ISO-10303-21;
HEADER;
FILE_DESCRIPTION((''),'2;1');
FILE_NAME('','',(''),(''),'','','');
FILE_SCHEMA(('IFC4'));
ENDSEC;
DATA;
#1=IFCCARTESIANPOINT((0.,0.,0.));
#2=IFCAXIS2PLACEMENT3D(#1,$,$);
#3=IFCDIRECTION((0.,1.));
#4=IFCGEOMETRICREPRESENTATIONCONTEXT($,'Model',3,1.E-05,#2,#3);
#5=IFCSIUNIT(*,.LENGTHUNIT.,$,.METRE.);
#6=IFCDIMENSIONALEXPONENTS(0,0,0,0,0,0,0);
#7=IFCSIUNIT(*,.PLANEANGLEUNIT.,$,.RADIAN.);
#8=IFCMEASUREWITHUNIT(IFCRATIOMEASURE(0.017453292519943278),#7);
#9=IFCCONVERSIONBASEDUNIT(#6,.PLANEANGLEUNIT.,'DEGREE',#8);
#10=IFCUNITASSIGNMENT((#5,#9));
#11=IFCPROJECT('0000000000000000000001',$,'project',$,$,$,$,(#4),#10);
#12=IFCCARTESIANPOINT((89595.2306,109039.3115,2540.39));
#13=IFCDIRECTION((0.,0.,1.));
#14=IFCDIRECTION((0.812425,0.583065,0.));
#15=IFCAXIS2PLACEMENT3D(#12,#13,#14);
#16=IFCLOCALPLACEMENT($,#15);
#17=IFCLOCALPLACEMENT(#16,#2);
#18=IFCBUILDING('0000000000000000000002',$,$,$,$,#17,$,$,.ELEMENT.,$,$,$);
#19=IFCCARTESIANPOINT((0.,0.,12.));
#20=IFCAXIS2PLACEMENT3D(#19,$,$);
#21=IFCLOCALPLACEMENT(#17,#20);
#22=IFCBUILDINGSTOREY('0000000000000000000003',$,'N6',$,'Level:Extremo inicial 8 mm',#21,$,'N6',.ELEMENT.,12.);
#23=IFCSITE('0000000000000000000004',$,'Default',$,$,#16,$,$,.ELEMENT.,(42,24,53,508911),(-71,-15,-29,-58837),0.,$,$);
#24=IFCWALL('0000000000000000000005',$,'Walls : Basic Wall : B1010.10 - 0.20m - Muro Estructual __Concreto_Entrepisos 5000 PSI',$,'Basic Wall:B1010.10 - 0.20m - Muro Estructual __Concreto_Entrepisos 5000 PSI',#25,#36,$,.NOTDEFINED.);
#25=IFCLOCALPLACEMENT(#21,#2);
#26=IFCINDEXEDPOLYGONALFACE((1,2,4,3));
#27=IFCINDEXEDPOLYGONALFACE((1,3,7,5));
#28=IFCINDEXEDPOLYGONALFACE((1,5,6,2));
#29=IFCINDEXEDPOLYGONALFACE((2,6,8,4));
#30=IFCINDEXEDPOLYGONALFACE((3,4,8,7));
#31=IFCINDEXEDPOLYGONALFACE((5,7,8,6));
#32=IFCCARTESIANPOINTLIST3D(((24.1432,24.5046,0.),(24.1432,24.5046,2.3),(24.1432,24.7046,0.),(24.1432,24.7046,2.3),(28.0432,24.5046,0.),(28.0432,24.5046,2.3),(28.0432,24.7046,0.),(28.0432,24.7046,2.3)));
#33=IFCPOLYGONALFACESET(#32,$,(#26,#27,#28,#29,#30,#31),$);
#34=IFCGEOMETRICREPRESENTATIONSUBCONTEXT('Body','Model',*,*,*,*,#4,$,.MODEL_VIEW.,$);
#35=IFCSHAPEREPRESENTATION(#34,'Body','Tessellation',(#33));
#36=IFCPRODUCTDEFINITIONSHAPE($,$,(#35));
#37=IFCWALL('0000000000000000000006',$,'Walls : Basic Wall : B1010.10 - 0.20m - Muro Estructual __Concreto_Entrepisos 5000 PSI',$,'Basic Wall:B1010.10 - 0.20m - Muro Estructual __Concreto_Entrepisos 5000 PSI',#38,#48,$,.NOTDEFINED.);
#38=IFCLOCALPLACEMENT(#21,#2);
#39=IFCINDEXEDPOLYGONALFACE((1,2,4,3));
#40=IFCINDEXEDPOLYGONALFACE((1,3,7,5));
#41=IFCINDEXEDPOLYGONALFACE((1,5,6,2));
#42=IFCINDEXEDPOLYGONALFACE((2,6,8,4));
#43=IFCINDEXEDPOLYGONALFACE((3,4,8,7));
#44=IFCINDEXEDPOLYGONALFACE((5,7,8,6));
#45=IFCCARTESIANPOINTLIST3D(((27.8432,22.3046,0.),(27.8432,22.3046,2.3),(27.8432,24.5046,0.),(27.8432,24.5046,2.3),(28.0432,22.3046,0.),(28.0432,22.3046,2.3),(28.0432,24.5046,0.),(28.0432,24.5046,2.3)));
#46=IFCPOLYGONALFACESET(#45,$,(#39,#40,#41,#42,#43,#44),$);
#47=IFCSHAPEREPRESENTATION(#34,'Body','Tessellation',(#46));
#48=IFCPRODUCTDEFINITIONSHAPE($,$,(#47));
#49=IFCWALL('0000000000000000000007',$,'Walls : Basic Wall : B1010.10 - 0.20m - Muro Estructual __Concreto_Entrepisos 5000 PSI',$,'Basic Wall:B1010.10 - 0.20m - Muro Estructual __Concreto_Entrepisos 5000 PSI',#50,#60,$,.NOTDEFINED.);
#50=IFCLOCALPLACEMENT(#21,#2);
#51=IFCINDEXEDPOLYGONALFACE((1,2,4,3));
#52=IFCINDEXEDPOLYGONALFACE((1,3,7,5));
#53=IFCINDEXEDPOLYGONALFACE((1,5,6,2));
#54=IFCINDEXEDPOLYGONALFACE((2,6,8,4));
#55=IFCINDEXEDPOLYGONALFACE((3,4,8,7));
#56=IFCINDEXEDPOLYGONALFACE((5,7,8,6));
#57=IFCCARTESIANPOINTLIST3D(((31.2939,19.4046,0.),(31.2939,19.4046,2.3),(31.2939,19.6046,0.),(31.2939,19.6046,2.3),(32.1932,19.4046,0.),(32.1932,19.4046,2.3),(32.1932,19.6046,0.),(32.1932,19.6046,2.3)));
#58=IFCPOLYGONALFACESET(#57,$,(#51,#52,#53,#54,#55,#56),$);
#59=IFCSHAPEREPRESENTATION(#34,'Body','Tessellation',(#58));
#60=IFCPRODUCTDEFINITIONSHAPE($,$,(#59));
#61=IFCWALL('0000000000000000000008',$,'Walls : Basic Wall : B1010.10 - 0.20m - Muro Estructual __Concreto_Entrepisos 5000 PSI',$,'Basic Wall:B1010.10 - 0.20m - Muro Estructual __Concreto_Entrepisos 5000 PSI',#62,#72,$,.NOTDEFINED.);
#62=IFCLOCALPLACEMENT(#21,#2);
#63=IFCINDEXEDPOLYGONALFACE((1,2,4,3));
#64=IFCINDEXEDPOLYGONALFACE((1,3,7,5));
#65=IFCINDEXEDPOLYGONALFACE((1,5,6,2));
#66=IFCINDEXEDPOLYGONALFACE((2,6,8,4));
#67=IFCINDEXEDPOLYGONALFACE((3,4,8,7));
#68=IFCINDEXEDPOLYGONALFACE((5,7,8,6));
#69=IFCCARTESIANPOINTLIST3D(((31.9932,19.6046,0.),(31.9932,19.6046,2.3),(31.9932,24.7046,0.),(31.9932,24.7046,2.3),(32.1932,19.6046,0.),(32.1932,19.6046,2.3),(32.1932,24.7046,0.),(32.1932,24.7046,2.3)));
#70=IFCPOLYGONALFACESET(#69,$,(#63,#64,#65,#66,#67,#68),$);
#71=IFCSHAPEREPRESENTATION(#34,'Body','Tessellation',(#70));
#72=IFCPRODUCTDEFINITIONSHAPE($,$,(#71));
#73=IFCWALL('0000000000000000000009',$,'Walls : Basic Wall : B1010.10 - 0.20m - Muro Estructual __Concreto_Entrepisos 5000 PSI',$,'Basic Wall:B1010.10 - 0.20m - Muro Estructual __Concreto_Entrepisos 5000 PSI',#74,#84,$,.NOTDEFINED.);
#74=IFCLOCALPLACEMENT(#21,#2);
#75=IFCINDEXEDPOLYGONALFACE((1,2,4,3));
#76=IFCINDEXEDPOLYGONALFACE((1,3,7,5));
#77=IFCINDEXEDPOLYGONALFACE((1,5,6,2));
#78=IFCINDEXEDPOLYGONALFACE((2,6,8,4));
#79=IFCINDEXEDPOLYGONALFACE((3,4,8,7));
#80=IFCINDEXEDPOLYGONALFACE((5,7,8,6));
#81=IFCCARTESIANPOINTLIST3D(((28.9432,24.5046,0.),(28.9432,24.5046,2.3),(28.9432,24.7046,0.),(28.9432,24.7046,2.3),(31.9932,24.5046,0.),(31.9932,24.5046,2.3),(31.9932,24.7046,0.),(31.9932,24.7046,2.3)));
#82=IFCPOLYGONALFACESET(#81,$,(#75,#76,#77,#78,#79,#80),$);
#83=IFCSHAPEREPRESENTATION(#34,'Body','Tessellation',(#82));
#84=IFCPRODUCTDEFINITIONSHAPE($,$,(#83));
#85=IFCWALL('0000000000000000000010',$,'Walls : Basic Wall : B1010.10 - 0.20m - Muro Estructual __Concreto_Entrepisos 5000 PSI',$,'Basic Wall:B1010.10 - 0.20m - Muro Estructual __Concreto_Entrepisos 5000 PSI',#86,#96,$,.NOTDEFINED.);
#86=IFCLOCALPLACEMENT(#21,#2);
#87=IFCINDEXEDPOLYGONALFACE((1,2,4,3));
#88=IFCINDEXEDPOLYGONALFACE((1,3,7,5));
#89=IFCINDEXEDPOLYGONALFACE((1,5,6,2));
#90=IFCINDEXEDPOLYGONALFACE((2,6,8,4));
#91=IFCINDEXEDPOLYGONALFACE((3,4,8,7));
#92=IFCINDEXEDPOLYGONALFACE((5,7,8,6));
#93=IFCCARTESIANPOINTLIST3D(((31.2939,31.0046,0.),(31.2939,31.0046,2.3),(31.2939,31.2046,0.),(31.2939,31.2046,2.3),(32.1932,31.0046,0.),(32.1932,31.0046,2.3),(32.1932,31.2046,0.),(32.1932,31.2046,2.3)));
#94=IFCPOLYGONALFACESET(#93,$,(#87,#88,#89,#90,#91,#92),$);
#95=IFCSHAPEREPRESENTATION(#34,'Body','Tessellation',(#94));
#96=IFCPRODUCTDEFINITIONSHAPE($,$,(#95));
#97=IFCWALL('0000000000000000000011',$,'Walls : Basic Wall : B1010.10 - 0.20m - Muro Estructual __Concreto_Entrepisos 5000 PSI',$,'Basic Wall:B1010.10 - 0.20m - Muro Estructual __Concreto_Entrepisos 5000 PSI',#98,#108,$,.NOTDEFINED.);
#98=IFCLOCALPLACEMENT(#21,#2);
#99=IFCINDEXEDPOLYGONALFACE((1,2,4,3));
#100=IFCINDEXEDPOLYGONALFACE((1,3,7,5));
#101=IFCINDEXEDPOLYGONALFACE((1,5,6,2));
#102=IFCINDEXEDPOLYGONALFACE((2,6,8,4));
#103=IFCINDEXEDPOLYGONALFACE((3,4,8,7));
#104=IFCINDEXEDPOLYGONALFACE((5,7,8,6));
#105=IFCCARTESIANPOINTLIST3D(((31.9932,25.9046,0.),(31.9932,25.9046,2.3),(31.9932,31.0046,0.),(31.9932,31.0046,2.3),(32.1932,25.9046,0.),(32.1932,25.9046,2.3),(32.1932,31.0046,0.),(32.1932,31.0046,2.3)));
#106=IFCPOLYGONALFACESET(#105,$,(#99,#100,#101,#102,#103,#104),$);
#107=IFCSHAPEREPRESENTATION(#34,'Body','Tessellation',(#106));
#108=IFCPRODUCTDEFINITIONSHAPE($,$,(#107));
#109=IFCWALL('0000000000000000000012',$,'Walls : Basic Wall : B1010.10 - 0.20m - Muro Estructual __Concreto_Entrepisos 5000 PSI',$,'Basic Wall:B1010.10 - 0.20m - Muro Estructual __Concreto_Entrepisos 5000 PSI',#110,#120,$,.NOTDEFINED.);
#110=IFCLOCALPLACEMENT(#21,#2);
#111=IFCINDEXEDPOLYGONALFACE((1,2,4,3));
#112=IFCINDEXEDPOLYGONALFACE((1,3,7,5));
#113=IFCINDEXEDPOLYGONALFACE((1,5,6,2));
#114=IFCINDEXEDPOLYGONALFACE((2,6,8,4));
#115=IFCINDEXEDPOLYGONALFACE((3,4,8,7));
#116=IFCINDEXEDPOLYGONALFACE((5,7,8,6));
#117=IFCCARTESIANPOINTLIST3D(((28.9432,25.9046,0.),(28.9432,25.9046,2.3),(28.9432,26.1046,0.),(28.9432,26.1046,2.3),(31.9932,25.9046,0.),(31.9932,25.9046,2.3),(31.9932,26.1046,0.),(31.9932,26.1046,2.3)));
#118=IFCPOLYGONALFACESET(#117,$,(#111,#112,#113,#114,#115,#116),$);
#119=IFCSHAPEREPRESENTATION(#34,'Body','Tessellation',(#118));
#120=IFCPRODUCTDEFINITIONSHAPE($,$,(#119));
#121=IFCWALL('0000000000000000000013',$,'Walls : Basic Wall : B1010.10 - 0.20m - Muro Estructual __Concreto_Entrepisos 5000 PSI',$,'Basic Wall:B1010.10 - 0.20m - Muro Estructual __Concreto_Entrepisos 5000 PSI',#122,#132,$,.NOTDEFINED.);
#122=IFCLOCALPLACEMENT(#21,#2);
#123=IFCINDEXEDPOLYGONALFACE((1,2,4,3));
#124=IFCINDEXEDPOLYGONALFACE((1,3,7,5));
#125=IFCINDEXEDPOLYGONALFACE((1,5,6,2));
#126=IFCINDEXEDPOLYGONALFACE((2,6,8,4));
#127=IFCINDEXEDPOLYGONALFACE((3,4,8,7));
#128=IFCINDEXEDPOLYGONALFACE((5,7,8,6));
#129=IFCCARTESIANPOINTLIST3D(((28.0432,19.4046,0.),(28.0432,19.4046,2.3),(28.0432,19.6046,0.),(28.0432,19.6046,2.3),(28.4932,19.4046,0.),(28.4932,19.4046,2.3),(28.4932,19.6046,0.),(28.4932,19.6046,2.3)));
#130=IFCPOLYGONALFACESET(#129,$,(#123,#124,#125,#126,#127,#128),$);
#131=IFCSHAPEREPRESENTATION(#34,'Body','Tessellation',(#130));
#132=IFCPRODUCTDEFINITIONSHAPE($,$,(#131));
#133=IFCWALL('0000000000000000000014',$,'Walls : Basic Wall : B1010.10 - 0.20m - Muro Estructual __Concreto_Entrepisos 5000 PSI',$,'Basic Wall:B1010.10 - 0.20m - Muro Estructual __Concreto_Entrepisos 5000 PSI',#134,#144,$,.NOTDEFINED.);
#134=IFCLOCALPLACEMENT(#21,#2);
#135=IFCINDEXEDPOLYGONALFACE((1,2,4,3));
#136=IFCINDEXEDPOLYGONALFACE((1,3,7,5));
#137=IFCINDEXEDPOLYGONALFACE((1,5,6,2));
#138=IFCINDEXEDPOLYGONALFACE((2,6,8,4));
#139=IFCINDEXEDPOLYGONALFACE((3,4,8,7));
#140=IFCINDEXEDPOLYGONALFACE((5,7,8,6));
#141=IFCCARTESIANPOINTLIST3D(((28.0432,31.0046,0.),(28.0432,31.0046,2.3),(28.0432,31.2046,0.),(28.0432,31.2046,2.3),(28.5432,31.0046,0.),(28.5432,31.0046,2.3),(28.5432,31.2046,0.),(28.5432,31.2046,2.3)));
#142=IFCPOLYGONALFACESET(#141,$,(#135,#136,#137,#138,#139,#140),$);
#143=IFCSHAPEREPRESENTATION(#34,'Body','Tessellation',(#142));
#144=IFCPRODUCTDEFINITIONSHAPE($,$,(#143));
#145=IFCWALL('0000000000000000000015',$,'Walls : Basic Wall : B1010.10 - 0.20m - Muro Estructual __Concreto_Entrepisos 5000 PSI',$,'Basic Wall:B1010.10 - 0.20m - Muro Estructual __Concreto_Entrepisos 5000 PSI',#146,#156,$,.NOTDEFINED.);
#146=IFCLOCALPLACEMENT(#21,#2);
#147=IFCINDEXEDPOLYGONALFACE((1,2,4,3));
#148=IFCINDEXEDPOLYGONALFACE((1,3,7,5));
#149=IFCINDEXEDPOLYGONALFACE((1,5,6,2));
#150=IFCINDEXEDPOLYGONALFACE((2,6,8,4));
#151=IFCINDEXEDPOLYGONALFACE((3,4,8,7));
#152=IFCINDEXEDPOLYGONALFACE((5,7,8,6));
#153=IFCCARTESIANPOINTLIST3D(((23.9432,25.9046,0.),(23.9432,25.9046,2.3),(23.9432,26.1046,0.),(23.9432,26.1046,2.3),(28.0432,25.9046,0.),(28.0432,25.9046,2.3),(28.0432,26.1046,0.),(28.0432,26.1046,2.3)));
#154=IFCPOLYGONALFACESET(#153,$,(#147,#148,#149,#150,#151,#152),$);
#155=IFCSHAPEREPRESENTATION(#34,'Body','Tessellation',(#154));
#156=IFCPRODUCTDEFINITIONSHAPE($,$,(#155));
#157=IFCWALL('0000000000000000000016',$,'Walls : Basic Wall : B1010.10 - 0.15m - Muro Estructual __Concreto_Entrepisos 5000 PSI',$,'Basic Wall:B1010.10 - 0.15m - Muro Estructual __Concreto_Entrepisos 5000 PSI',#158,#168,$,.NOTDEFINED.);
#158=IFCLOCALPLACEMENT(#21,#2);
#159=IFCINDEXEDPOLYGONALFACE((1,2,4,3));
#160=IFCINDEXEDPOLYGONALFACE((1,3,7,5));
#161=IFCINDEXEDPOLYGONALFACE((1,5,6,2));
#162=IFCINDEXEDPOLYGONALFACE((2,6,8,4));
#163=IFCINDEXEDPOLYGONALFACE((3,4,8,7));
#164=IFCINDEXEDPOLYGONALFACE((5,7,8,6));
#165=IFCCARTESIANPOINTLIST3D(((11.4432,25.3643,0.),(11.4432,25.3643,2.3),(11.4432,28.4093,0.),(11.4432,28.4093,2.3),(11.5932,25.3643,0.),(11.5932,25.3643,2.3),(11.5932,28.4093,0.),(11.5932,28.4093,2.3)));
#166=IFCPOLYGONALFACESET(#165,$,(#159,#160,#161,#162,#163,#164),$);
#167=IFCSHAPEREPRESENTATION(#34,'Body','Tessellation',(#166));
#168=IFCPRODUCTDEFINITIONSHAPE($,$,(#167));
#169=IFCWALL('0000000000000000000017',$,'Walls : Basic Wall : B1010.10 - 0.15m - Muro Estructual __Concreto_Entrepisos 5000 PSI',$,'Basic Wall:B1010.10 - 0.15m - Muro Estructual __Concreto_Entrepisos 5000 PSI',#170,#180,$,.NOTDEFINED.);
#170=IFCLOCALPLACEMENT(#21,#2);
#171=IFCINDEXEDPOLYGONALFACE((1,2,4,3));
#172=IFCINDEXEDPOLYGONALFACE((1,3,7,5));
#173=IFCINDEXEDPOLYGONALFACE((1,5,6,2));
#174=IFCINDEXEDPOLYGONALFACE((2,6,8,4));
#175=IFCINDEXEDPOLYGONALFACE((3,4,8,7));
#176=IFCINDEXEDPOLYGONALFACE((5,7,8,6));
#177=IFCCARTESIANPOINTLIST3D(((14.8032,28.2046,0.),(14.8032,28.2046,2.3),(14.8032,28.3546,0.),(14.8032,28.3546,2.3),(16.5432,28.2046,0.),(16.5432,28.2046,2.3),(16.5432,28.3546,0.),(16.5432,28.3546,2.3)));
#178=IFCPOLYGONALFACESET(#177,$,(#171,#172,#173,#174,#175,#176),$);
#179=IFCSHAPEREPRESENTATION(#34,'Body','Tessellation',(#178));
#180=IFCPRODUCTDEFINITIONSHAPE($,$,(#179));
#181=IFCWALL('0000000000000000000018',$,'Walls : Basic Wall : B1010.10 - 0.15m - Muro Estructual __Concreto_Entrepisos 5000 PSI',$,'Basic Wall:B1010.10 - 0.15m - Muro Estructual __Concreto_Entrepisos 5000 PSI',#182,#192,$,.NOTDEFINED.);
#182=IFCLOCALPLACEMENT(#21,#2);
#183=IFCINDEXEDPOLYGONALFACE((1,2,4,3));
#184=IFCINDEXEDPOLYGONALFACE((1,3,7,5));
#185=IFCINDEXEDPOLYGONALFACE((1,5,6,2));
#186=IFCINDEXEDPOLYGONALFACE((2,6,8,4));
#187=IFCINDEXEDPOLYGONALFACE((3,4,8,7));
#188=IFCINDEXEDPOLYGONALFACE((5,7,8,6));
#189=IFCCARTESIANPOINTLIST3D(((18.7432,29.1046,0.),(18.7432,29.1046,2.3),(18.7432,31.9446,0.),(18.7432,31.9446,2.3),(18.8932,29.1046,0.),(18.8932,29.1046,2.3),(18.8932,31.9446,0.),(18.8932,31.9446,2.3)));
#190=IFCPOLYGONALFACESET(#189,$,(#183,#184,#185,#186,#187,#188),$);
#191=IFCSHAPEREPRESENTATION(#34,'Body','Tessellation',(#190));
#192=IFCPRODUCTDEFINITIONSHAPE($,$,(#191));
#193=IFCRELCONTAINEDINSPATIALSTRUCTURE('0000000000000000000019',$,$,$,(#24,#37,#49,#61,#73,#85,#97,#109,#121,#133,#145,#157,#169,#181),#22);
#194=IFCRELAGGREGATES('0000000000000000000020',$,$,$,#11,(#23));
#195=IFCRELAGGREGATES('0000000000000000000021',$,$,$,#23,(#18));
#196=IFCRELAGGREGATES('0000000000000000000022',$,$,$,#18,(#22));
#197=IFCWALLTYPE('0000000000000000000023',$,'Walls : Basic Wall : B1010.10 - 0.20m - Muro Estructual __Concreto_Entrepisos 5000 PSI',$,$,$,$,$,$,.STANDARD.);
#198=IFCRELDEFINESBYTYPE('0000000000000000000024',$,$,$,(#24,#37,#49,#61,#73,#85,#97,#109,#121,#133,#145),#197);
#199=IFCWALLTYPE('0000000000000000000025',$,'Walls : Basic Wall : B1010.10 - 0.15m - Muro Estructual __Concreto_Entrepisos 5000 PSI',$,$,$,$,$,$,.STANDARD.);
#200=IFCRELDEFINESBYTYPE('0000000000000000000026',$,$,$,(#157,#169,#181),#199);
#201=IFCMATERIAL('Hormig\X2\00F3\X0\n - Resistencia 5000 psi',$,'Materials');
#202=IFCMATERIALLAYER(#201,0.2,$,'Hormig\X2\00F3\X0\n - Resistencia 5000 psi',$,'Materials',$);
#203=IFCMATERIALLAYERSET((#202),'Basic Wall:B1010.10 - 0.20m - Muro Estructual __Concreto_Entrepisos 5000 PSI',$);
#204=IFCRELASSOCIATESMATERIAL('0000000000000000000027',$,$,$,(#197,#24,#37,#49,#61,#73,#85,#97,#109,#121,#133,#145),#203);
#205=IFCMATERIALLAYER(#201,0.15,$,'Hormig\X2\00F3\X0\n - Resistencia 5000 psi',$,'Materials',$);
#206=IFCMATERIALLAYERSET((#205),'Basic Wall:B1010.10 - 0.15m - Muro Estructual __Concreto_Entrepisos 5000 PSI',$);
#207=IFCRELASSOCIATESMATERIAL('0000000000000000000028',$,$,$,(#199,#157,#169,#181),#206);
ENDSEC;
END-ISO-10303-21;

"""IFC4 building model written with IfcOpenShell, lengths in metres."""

from ifc_helpers import new_model, entity, si_unit, converted_unit, direction, frame, frame_2d, origin, place, context, subcontext, project, spatial, rectangle, extrude, material, layer, layer_set, layer_usage, type_object, element, save


model = new_model("IFC4")

# Units and contexts
model_context = context("Model", 3, precision=1e-05, world=origin(), true_north=direction((0.0, 1.0)))
body_context = subcontext(model_context, "Body", "Model", "MODEL_VIEW")
ifc_project = project(units=[si_unit("LENGTHUNIT", "METRE"), converted_unit("PLANEANGLEUNIT", "DEGREE", entity("IfcRatioMeasure", 0.017453292519943278), si_unit("PLANEANGLEUNIT", "RADIAN"), dimensions=[0, 0, 0, 0, 0, 0, 0])], contexts=[model_context])

# Site, building, storey
site_placement = place(None, frame((89595.2306, 109039.3115, 2540.39), z_axis=(0.0, 0.0, 1.0), x_axis=(0.812425, 0.583065, 0.0)))
site = spatial("IfcSite", under=ifc_project, at=site_placement, Name="Default", CompositionType="ELEMENT", RefLatitude=(42, 24, 53, 508911), RefLongitude=(-71, -15, -29, -58837), RefElevation=0.0)
building_placement = place(site_placement, origin())
building = spatial("IfcBuilding", under=site, at=building_placement, CompositionType="ELEMENT")
storey_placement = place(building_placement, frame((0.0, 0.0, 12.0)))
storey = spatial("IfcBuildingStorey", under=building, at=storey_placement, Name="N6", ObjectType="Level:Extremo inicial 8 mm", LongName="N6", CompositionType="ELEMENT", Elevation=12.0)

# Walls
ifc_material_1 = material(Name="Hormigón - Resistencia 5000 psi", Category="Materials")
ifc_layer_1 = layer(ifc_material_1, 0.2, Name="Hormigón - Resistencia 5000 psi", Category="Materials")
ifc_layer_set_1 = layer_set([ifc_layer_1], Name="Basic Wall:B1010.10 - 0.20m - Muro Estructual __Concreto_Entrepisos 5000 PSI")
wall_type_1 = type_object("IfcWallType", Name="Walls : Basic Wall : B1010.10 - 0.20m - Muro Estructual __Concreto_Entrepisos 5000 PSI", PredefinedType="STANDARD", material=ifc_layer_set_1)
ifc_layer_usage_1 = layer_usage(ifc_layer_set_1, "AXIS2", "NEGATIVE", 0.1)
wall_1_placement = place(storey_placement, frame((24.1432, 24.6046, 0.0)))
element("IfcWall", 1, at=wall_1_placement, inside=storey, type_object=wall_type_1, material=ifc_layer_usage_1, Name="Walls : Basic Wall : B1010.10 - 0.20m - Muro Estructual __Concreto_Entrepisos 5000 PSI", ObjectType="Basic Wall:B1010.10 - 0.20m - Muro Estructual __Concreto_Entrepisos 5000 PSI", PredefinedType="NOTDEFINED", context=body_context, shape_type="SweptSolid", body=[
    extrude(rectangle(XDim=3.9, YDim=0.2, at=frame_2d((1.95, 0.0), x_axis=(-1.0, 0.0))), origin(), (0.0, 0.0, 1.0), 2.3),
])
ifc_layer_usage_2 = layer_usage(ifc_layer_set_1, "AXIS2", "NEGATIVE", 0.1)
wall_2_placement = place(storey_placement, frame((27.9432, 24.5046, 0.0), z_axis=(0.0, 0.0, 1.0), x_axis=(0.0, -1.0, 0.0)))
element("IfcWall", 2, at=wall_2_placement, inside=storey, type_object=wall_type_1, material=ifc_layer_usage_2, Name="Walls : Basic Wall : B1010.10 - 0.20m - Muro Estructual __Concreto_Entrepisos 5000 PSI", ObjectType="Basic Wall:B1010.10 - 0.20m - Muro Estructual __Concreto_Entrepisos 5000 PSI", PredefinedType="NOTDEFINED", context=body_context, shape_type="SweptSolid", body=[
    extrude(rectangle(XDim=2.2, YDim=0.2, at=frame_2d((1.1, 0.0), x_axis=(-1.0, 0.0))), origin(), (0.0, 0.0, 1.0), 2.3),
])
ifc_layer_usage_3 = layer_usage(ifc_layer_set_1, "AXIS2", "NEGATIVE", 0.1)
wall_3_placement = place(storey_placement, frame((31.2939, 19.5046, 0.0)))
element("IfcWall", 3, at=wall_3_placement, inside=storey, type_object=wall_type_1, material=ifc_layer_usage_3, Name="Walls : Basic Wall : B1010.10 - 0.20m - Muro Estructual __Concreto_Entrepisos 5000 PSI", ObjectType="Basic Wall:B1010.10 - 0.20m - Muro Estructual __Concreto_Entrepisos 5000 PSI", PredefinedType="NOTDEFINED", context=body_context, shape_type="SweptSolid", body=[
    extrude(rectangle(XDim=0.8993, YDim=0.2, at=frame_2d((0.4497, 0.0), x_axis=(-1.0, 0.0))), origin(), (0.0, 0.0, 1.0), 2.3),
])
ifc_layer_usage_4 = layer_usage(ifc_layer_set_1, "AXIS2", "NEGATIVE", 0.1)
wall_4_placement = place(storey_placement, frame((32.0932, 19.6046, 0.0), z_axis=(0.0, 0.0, 1.0), x_axis=(0.0, 1.0, 0.0)))
element("IfcWall", 4, at=wall_4_placement, inside=storey, type_object=wall_type_1, material=ifc_layer_usage_4, Name="Walls : Basic Wall : B1010.10 - 0.20m - Muro Estructual __Concreto_Entrepisos 5000 PSI", ObjectType="Basic Wall:B1010.10 - 0.20m - Muro Estructual __Concreto_Entrepisos 5000 PSI", PredefinedType="NOTDEFINED", context=body_context, shape_type="SweptSolid", body=[
    extrude(rectangle(XDim=5.1, YDim=0.2, at=frame_2d((2.55, 0.0), x_axis=(-1.0, 0.0))), origin(), (0.0, 0.0, 1.0), 2.3),
])
ifc_layer_usage_5 = layer_usage(ifc_layer_set_1, "AXIS2", "NEGATIVE", 0.1)
wall_5_placement = place(storey_placement, frame((31.9932, 24.6046, 0.0), z_axis=(0.0, 0.0, 1.0), x_axis=(-1.0, 0.0, 0.0)))
element("IfcWall", 5, at=wall_5_placement, inside=storey, type_object=wall_type_1, material=ifc_layer_usage_5, Name="Walls : Basic Wall : B1010.10 - 0.20m - Muro Estructual __Concreto_Entrepisos 5000 PSI", ObjectType="Basic Wall:B1010.10 - 0.20m - Muro Estructual __Concreto_Entrepisos 5000 PSI", PredefinedType="NOTDEFINED", context=body_context, shape_type="SweptSolid", body=[
    extrude(rectangle(XDim=3.05, YDim=0.2, at=frame_2d((1.525, 0.0), x_axis=(-1.0, 0.0))), origin(), (0.0, 0.0, 1.0), 2.3),
])
ifc_layer_usage_6 = layer_usage(ifc_layer_set_1, "AXIS2", "POSITIVE", -0.1)
wall_6_placement = place(storey_placement, frame((31.2939, 31.1046, 0.0)))
element("IfcWall", 6, at=wall_6_placement, inside=storey, type_object=wall_type_1, material=ifc_layer_usage_6, Name="Walls : Basic Wall : B1010.10 - 0.20m - Muro Estructual __Concreto_Entrepisos 5000 PSI", ObjectType="Basic Wall:B1010.10 - 0.20m - Muro Estructual __Concreto_Entrepisos 5000 PSI", PredefinedType="NOTDEFINED", context=body_context, shape_type="SweptSolid", body=[
    extrude(rectangle(XDim=0.8993, YDim=0.2, at=frame_2d((0.4497, 0.0), x_axis=(-1.0, 0.0))), origin(), (0.0, 0.0, 1.0), 2.3),
])
ifc_layer_usage_7 = layer_usage(ifc_layer_set_1, "AXIS2", "POSITIVE", -0.1)
wall_7_placement = place(storey_placement, frame((32.0932, 31.0046, 0.0), z_axis=(0.0, 0.0, 1.0), x_axis=(0.0, -1.0, 0.0)))
element("IfcWall", 7, at=wall_7_placement, inside=storey, type_object=wall_type_1, material=ifc_layer_usage_7, Name="Walls : Basic Wall : B1010.10 - 0.20m - Muro Estructual __Concreto_Entrepisos 5000 PSI", ObjectType="Basic Wall:B1010.10 - 0.20m - Muro Estructual __Concreto_Entrepisos 5000 PSI", PredefinedType="NOTDEFINED", context=body_context, shape_type="SweptSolid", body=[
    extrude(rectangle(XDim=5.1, YDim=0.2, at=frame_2d((2.55, 0.0), x_axis=(-1.0, 0.0))), origin(), (0.0, 0.0, 1.0), 2.3),
])
ifc_layer_usage_8 = layer_usage(ifc_layer_set_1, "AXIS2", "POSITIVE", -0.1)
wall_8_placement = place(storey_placement, frame((31.9932, 26.0046, 0.0), z_axis=(0.0, 0.0, 1.0), x_axis=(-1.0, 0.0, 0.0)))
element("IfcWall", 8, at=wall_8_placement, inside=storey, type_object=wall_type_1, material=ifc_layer_usage_8, Name="Walls : Basic Wall : B1010.10 - 0.20m - Muro Estructual __Concreto_Entrepisos 5000 PSI", ObjectType="Basic Wall:B1010.10 - 0.20m - Muro Estructual __Concreto_Entrepisos 5000 PSI", PredefinedType="NOTDEFINED", context=body_context, shape_type="SweptSolid", body=[
    extrude(rectangle(XDim=3.05, YDim=0.2, at=frame_2d((1.525, 0.0), x_axis=(-1.0, 0.0))), origin(), (0.0, 0.0, 1.0), 2.3),
])
ifc_layer_usage_9 = layer_usage(ifc_layer_set_1, "AXIS2", "NEGATIVE", 0.1)
wall_9_placement = place(storey_placement, frame((28.4932, 19.5046, 0.0), z_axis=(0.0, 0.0, 1.0), x_axis=(-1.0, 0.0, 0.0)))
element("IfcWall", 9, at=wall_9_placement, inside=storey, type_object=wall_type_1, material=ifc_layer_usage_9, Name="Walls : Basic Wall : B1010.10 - 0.20m - Muro Estructual __Concreto_Entrepisos 5000 PSI", ObjectType="Basic Wall:B1010.10 - 0.20m - Muro Estructual __Concreto_Entrepisos 5000 PSI", PredefinedType="NOTDEFINED", context=body_context, shape_type="SweptSolid", body=[
    extrude(rectangle(XDim=0.45, YDim=0.2, at=frame_2d((0.225, 0.0), x_axis=(-1.0, 0.0))), origin(), (0.0, 0.0, 1.0), 2.3),
])
ifc_layer_usage_10 = layer_usage(ifc_layer_set_1, "AXIS2", "NEGATIVE", 0.1)
wall_10_placement = place(storey_placement, frame((28.5432, 31.1046, 0.0), z_axis=(0.0, 0.0, 1.0), x_axis=(-1.0, 0.0, 0.0)))
element("IfcWall", 10, at=wall_10_placement, inside=storey, type_object=wall_type_1, material=ifc_layer_usage_10, Name="Walls : Basic Wall : B1010.10 - 0.20m - Muro Estructual __Concreto_Entrepisos 5000 PSI", ObjectType="Basic Wall:B1010.10 - 0.20m - Muro Estructual __Concreto_Entrepisos 5000 PSI", PredefinedType="NOTDEFINED", context=body_context, shape_type="SweptSolid", body=[
    extrude(rectangle(XDim=0.5, YDim=0.2, at=frame_2d((0.25, 0.0), x_axis=(-1.0, 0.0))), origin(), (0.0, 0.0, 1.0), 2.3),
])
ifc_layer_usage_11 = layer_usage(ifc_layer_set_1, "AXIS2", "NEGATIVE", 0.1)
wall_11_placement = place(storey_placement, frame((23.9432, 26.0046, 0.0)))
element("IfcWall", 11, at=wall_11_placement, inside=storey, type_object=wall_type_1, material=ifc_layer_usage_11, Name="Walls : Basic Wall : B1010.10 - 0.20m - Muro Estructual __Concreto_Entrepisos 5000 PSI", ObjectType="Basic Wall:B1010.10 - 0.20m - Muro Estructual __Concreto_Entrepisos 5000 PSI", PredefinedType="NOTDEFINED", context=body_context, shape_type="SweptSolid", body=[
    extrude(rectangle(XDim=4.1, YDim=0.2, at=frame_2d((2.05, 0.0), x_axis=(-1.0, 0.0))), origin(), (0.0, 0.0, 1.0), 2.3),
])
ifc_layer_2 = layer(ifc_material_1, 0.15, Name="Hormigón - Resistencia 5000 psi", Category="Materials")
ifc_layer_set_2 = layer_set([ifc_layer_2], Name="Basic Wall:B1010.10 - 0.15m - Muro Estructual __Concreto_Entrepisos 5000 PSI")
ifc_layer_usage_12 = layer_usage(ifc_layer_set_2, "AXIS2", "NEGATIVE", 0.075)
wall_type_2 = type_object("IfcWallType", Name="Walls : Basic Wall : B1010.10 - 0.15m - Muro Estructual __Concreto_Entrepisos 5000 PSI", PredefinedType="STANDARD", material=ifc_layer_set_2)
wall_12_placement = place(storey_placement, frame((11.5182, 25.3643, 0.0), z_axis=(0.0, 0.0, 1.0), x_axis=(0.0, 1.0, 0.0)))
element("IfcWall", 12, at=wall_12_placement, inside=storey, type_object=wall_type_2, material=ifc_layer_usage_12, Name="Walls : Basic Wall : B1010.10 - 0.15m - Muro Estructual __Concreto_Entrepisos 5000 PSI", ObjectType="Basic Wall:B1010.10 - 0.15m - Muro Estructual __Concreto_Entrepisos 5000 PSI", PredefinedType="NOTDEFINED", context=body_context, shape_type="SweptSolid", body=[
    extrude(rectangle(XDim=3.045, YDim=0.15, at=frame_2d((1.5225, 0.0), x_axis=(-1.0, 0.0))), origin(), (0.0, 0.0, 1.0), 2.3),
])
ifc_layer_usage_13 = layer_usage(ifc_layer_set_2, "AXIS2", "NEGATIVE", 0.075)
wall_13_placement = place(storey_placement, frame((16.5432, 28.2796, 0.0), z_axis=(0.0, 0.0, 1.0), x_axis=(-1.0, 0.0, 0.0)))
element("IfcWall", 13, at=wall_13_placement, inside=storey, type_object=wall_type_2, material=ifc_layer_usage_13, Name="Walls : Basic Wall : B1010.10 - 0.15m - Muro Estructual __Concreto_Entrepisos 5000 PSI", ObjectType="Basic Wall:B1010.10 - 0.15m - Muro Estructual __Concreto_Entrepisos 5000 PSI", PredefinedType="NOTDEFINED", context=body_context, shape_type="SweptSolid", body=[
    extrude(rectangle(XDim=1.74, YDim=0.15, at=frame_2d((0.87, 0.0), x_axis=(-1.0, 0.0))), origin(), (0.0, 0.0, 1.0), 2.3),
])
ifc_layer_usage_14 = layer_usage(ifc_layer_set_2, "AXIS2", "NEGATIVE", 0.075)
wall_14_placement = place(storey_placement, frame((18.8182, 31.9446, 0.0), z_axis=(0.0, 0.0, 1.0), x_axis=(0.0, -1.0, 0.0)))
element("IfcWall", 14, at=wall_14_placement, inside=storey, type_object=wall_type_2, material=ifc_layer_usage_14, Name="Walls : Basic Wall : B1010.10 - 0.15m - Muro Estructual __Concreto_Entrepisos 5000 PSI", ObjectType="Basic Wall:B1010.10 - 0.15m - Muro Estructual __Concreto_Entrepisos 5000 PSI", PredefinedType="NOTDEFINED", context=body_context, shape_type="SweptSolid", body=[
    extrude(rectangle(XDim=2.84, YDim=0.15, at=frame_2d((1.42, 0.0), x_axis=(-1.0, 0.0))), origin(), (0.0, 0.0, 1.0), 2.3),
])

save(model, "model.ifc")
